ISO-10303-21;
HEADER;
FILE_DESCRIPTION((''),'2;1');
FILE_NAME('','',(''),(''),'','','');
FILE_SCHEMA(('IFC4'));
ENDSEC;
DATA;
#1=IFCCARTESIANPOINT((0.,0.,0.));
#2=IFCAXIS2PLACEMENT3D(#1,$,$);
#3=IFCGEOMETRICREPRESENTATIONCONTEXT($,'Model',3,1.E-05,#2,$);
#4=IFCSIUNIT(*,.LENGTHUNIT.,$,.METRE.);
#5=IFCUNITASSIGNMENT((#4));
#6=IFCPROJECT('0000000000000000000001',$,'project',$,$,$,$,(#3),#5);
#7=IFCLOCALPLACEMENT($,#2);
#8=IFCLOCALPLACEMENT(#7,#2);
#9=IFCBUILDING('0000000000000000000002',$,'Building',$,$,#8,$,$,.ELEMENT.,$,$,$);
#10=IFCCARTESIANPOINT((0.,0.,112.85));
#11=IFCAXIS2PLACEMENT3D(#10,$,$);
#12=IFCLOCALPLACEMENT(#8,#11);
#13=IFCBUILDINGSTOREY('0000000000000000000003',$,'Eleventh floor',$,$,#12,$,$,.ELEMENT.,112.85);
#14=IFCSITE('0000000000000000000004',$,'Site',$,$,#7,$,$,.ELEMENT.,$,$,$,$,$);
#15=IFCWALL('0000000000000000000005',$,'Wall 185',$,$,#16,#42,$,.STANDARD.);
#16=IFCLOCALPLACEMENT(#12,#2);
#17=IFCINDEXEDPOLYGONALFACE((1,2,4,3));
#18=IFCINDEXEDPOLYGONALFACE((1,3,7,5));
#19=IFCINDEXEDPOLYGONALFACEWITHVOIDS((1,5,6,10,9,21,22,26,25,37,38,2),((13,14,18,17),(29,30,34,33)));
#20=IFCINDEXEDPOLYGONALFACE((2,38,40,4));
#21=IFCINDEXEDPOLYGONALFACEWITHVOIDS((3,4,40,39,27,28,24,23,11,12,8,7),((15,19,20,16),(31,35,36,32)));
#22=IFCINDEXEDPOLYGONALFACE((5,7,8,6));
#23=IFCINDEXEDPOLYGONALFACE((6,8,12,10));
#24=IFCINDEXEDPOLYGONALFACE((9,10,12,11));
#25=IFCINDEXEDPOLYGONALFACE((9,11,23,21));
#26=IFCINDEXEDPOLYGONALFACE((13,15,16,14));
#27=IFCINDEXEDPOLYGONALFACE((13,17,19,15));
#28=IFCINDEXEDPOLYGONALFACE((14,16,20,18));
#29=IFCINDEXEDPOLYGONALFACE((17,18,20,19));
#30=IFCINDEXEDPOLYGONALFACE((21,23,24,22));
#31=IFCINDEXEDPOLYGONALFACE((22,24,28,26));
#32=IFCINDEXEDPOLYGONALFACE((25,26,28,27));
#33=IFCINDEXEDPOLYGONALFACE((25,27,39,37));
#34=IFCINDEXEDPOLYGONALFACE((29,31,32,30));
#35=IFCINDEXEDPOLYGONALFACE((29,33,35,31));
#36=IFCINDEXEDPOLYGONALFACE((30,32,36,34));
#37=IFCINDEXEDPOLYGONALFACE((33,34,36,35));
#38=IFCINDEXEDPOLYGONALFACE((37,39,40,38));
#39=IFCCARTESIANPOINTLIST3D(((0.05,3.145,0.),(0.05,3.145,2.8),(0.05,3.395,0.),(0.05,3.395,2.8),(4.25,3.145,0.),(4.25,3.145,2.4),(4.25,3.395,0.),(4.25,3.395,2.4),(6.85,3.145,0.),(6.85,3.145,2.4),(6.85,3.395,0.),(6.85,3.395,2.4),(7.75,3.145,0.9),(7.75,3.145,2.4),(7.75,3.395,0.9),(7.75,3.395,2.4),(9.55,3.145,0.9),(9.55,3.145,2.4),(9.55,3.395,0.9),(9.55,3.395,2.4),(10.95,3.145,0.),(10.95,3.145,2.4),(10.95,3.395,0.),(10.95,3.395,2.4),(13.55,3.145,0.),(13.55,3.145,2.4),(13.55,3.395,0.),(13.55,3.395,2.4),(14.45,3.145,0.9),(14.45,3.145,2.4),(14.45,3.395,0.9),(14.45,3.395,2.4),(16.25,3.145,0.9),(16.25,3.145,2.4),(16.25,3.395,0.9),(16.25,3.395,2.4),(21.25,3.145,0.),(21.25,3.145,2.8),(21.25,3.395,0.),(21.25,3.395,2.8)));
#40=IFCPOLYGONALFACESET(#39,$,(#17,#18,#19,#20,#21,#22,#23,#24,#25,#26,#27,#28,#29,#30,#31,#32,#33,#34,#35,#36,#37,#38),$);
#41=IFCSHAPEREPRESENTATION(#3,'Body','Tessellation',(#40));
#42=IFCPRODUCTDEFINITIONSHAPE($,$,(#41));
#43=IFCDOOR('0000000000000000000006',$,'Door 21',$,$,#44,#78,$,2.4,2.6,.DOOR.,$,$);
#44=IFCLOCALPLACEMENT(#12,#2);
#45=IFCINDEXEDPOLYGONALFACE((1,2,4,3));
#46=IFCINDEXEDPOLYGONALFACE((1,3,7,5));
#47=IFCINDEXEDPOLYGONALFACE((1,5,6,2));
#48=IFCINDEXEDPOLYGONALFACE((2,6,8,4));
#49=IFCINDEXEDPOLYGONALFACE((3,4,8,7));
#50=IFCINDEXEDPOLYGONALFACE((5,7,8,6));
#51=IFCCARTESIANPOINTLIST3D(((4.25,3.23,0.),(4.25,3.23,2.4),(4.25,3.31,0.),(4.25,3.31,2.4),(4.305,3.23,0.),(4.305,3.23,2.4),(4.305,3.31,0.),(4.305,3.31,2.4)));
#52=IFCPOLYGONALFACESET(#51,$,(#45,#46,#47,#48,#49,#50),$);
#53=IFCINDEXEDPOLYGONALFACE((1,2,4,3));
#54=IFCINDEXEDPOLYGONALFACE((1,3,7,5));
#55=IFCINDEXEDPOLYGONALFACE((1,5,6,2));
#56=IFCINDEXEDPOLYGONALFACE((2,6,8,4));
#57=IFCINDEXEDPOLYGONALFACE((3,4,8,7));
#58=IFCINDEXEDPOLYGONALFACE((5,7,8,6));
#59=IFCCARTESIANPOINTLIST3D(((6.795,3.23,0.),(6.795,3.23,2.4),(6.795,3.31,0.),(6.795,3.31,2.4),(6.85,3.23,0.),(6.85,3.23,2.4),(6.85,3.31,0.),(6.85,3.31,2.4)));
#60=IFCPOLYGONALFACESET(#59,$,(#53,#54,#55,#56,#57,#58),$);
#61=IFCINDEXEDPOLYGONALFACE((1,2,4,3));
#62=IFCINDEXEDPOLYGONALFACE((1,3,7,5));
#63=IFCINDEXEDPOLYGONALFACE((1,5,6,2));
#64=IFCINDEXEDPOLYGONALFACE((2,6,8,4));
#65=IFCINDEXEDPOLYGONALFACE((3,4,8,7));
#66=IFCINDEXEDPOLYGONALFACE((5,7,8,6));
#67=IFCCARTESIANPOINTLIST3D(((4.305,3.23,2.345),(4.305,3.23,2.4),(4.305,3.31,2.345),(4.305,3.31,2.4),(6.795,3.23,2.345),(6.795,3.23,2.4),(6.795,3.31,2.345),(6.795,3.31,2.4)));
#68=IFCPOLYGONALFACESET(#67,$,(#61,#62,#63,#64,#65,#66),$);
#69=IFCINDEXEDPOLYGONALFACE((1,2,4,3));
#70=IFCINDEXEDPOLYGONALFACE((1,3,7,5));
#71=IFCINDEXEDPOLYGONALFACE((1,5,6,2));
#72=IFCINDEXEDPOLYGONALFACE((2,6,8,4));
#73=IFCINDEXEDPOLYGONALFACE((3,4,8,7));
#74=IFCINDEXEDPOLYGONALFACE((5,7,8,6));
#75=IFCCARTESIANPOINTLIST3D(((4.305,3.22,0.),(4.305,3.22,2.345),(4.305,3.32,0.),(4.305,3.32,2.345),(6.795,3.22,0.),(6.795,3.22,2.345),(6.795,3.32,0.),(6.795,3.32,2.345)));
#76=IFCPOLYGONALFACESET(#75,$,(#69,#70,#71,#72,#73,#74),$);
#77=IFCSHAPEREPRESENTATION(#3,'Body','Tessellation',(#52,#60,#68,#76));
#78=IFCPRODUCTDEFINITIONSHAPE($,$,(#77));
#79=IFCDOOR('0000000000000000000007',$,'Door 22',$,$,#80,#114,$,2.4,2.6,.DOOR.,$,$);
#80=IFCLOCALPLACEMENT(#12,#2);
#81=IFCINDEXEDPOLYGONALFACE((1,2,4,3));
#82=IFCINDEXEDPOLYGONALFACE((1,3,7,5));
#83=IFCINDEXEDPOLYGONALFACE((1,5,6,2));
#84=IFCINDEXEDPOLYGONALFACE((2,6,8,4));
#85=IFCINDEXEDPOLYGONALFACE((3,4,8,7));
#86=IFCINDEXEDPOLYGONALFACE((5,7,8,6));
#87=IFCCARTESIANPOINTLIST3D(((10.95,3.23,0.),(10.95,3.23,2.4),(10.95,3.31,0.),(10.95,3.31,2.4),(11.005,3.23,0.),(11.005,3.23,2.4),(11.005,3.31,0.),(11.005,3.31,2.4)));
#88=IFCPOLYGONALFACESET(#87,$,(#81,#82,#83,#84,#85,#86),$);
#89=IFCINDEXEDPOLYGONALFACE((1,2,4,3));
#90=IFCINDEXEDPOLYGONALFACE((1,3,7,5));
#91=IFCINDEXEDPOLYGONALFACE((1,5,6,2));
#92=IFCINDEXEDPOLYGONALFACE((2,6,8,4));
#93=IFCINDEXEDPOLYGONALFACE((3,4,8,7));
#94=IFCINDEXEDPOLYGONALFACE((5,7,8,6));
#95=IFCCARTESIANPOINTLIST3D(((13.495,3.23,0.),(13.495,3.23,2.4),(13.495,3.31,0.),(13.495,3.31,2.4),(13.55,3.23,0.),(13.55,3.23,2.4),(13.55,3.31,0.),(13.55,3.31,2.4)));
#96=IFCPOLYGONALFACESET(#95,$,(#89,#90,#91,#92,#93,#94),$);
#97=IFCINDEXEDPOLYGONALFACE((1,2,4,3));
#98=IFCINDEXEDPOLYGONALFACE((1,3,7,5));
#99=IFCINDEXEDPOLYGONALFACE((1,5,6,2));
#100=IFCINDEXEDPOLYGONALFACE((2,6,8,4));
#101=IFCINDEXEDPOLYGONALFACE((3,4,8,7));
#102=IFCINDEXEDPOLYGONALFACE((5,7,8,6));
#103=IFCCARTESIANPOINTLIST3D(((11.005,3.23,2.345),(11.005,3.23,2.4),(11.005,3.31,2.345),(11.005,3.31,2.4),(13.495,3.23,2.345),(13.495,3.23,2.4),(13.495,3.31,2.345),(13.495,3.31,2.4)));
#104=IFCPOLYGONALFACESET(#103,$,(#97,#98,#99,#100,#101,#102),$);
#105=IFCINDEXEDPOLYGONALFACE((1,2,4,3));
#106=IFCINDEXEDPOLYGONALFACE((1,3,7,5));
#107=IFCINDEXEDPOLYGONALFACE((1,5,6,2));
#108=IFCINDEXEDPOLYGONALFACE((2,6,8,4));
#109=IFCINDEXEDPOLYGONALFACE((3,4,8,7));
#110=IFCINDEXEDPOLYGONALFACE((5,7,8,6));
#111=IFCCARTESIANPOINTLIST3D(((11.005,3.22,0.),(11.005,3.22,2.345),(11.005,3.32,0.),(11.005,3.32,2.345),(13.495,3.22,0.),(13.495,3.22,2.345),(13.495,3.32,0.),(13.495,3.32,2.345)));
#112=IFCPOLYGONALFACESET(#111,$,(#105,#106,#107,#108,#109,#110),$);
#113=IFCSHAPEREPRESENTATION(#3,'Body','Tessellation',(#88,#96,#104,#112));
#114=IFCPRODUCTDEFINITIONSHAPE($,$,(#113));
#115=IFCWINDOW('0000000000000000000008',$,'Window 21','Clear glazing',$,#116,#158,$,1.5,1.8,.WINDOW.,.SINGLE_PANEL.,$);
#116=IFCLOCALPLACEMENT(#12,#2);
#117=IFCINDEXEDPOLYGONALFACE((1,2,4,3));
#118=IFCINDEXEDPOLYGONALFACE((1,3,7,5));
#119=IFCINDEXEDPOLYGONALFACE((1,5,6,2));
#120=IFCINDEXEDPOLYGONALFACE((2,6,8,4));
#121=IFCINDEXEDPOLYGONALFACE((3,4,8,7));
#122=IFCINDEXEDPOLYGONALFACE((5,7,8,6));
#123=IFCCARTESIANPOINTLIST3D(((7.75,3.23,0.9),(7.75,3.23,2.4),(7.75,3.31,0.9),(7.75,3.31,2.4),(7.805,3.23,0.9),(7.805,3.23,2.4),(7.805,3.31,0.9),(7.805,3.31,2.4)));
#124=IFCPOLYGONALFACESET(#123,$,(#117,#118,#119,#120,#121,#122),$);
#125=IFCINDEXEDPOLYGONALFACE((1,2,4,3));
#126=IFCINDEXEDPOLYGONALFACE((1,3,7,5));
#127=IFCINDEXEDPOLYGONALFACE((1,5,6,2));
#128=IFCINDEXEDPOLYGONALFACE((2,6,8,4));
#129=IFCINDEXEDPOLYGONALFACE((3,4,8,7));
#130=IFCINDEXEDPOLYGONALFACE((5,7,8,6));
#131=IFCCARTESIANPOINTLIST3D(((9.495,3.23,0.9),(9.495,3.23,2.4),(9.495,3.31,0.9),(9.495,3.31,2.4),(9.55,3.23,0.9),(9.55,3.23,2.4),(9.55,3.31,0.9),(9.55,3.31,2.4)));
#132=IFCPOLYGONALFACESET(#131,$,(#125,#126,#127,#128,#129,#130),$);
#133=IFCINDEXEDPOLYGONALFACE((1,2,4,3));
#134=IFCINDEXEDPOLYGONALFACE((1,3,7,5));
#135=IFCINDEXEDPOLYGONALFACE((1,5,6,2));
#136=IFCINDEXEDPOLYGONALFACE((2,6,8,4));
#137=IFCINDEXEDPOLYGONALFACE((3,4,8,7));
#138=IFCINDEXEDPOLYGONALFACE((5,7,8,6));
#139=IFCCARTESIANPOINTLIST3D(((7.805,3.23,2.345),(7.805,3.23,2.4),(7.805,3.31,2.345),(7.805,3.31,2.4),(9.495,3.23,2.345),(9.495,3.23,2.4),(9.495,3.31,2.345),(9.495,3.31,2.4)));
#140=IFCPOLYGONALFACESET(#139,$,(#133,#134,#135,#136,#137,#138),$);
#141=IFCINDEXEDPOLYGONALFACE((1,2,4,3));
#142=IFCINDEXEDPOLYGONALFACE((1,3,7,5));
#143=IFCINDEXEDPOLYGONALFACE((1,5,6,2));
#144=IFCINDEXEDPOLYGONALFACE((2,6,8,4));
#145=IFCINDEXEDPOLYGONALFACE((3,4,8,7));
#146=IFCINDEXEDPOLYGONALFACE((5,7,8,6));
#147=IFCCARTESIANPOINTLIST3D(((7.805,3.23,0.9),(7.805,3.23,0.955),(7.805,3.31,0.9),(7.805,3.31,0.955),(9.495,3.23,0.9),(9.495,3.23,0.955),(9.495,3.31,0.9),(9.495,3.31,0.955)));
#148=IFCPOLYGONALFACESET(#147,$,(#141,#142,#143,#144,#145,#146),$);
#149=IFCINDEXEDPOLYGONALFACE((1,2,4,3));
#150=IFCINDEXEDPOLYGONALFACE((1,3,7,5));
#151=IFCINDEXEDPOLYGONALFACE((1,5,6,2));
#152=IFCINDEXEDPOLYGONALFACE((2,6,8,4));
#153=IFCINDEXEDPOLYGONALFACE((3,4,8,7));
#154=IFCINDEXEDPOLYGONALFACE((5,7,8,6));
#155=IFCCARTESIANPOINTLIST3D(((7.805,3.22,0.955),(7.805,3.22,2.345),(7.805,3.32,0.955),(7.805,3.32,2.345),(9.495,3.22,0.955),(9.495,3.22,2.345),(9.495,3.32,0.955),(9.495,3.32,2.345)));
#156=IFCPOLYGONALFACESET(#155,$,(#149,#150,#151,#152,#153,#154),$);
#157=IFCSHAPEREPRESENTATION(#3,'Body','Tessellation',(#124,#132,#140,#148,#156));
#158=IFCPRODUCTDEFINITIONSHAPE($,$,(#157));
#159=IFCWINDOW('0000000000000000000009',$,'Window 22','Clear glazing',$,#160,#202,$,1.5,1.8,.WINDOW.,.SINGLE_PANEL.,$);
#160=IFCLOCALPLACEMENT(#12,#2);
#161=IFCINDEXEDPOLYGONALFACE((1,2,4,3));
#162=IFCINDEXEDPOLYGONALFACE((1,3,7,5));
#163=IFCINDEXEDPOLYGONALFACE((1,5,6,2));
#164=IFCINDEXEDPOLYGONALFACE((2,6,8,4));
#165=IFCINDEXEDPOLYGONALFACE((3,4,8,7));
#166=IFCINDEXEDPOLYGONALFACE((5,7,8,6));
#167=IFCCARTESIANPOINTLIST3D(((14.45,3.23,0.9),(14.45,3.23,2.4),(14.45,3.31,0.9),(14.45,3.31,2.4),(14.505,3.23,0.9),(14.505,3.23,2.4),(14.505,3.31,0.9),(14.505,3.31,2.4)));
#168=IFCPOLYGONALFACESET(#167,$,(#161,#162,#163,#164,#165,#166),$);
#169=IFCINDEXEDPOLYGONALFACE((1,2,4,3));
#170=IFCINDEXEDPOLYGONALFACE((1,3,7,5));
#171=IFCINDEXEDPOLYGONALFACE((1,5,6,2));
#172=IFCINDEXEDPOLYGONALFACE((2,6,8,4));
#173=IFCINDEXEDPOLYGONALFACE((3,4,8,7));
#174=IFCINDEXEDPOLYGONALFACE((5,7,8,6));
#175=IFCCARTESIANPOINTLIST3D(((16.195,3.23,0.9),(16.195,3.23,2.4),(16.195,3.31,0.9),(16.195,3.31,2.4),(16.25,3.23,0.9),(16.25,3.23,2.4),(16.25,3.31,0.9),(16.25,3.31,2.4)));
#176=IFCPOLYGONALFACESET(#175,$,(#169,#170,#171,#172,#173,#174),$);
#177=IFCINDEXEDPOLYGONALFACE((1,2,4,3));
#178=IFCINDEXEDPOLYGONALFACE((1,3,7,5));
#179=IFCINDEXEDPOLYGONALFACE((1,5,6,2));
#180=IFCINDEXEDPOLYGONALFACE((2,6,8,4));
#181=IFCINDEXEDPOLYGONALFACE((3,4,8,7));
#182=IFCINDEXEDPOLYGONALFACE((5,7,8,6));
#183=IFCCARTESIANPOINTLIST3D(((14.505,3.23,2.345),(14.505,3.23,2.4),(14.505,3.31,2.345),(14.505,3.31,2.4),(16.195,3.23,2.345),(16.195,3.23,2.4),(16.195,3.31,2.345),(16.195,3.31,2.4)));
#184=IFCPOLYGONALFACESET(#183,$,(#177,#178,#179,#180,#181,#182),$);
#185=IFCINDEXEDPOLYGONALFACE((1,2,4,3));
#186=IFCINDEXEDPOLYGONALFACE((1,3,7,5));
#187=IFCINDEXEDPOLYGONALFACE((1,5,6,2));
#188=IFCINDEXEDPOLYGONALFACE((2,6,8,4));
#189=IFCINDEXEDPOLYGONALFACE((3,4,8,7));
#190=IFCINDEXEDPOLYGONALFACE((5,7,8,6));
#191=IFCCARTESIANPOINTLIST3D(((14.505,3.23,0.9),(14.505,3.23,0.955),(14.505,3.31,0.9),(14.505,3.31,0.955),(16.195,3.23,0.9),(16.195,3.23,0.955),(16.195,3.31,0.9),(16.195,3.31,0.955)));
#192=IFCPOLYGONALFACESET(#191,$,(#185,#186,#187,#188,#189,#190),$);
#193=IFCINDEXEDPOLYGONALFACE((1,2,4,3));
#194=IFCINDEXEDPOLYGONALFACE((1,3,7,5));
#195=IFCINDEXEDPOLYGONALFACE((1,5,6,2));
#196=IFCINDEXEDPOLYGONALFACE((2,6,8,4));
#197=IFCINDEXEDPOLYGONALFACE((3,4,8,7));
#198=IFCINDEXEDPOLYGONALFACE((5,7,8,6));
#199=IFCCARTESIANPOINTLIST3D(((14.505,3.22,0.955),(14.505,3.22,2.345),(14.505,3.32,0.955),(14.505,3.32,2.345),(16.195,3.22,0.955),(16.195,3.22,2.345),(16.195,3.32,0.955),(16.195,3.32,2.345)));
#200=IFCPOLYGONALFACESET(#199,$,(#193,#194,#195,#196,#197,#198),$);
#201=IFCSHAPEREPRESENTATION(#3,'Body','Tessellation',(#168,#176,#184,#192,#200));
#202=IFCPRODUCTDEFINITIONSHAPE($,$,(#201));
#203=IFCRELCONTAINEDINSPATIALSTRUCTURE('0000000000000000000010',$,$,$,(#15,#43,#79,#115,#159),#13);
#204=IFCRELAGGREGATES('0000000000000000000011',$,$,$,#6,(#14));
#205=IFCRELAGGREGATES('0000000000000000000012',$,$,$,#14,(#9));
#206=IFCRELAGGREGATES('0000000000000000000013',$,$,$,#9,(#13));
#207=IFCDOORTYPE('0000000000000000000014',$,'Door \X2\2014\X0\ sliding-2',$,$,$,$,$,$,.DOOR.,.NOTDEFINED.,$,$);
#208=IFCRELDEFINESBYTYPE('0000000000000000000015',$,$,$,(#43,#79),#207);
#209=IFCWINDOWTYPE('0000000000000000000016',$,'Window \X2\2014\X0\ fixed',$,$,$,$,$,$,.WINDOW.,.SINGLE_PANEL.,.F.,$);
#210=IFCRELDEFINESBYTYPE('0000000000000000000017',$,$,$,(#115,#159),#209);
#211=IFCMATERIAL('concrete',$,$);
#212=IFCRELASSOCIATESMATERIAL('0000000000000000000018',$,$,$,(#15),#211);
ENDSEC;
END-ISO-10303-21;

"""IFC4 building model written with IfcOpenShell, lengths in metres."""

from ifc_helpers import new_model, si_unit, frame, frame_2d, origin, place, context, project, spatial, rectangle, extrude, material, type_object, element, fill, save


model = new_model("IFC4")

# Units and contexts
model_context = context("Model", 3, precision=1e-05, world=origin())
ifc_project = project(units=[si_unit("LENGTHUNIT", "METRE")], contexts=[model_context])

# Site, building, storey
site_placement = place(None, origin())
site = spatial("IfcSite", under=ifc_project, at=site_placement, Name="Site", CompositionType="ELEMENT")
building_placement = place(site_placement, origin())
building = spatial("IfcBuilding", under=site, at=building_placement, Name="Building", CompositionType="ELEMENT")
storey_placement = place(building_placement, frame((0.0, 0.0, 112.85)))
storey = spatial("IfcBuildingStorey", under=building, at=storey_placement, Name="Eleventh floor", CompositionType="ELEMENT", Elevation=112.85)

# Shared definitions
ifc_material = material(Name="concrete")

# Wall, openings, doors, windows
wall_1_placement = place(storey_placement, frame((0.05, 3.27, 0.0), z_axis=(0.0, 0.0, 1.0), x_axis=(1.0, 0.0, 0.0)))
wall_1 = element("IfcWall", 1, at=wall_1_placement, inside=storey, material=ifc_material, Name="Wall 185", PredefinedType="STANDARD", context=model_context, shape_type="SweptSolid", body=[
    extrude(rectangle(XDim=21.2, YDim=0.25, at=frame_2d((10.6, 0.0))), origin(), (0.0, 0.0, 1.0), 2.8),
])
opening_1_placement = place(storey_placement, frame((4.25, 3.27, 0.0), z_axis=(0.0, 0.0, 1.0), x_axis=(1.0, 0.0, 0.0)))
opening_1 = element("IfcOpeningElement", 2, at=opening_1_placement, cuts=wall_1, PredefinedType="OPENING", context=model_context, shape_type="SweptSolid", body=[
    extrude(rectangle(XDim=2.6, YDim=0.31, at=frame_2d((1.3, 0.0))), origin(), (0.0, 0.0, 1.0), 2.4),
])
opening_2_placement = place(storey_placement, frame((7.75, 3.27, 0.9), z_axis=(0.0, 0.0, 1.0), x_axis=(1.0, 0.0, 0.0)))
opening_2 = element("IfcOpeningElement", 3, at=opening_2_placement, cuts=wall_1, PredefinedType="OPENING", context=model_context, shape_type="SweptSolid", body=[
    extrude(rectangle(XDim=1.8, YDim=0.31, at=frame_2d((0.9, 0.0))), origin(), (0.0, 0.0, 1.0), 1.5),
])
opening_3_placement = place(storey_placement, frame((10.95, 3.27, 0.0), z_axis=(0.0, 0.0, 1.0), x_axis=(1.0, 0.0, 0.0)))
opening_3 = element("IfcOpeningElement", 4, at=opening_3_placement, cuts=wall_1, PredefinedType="OPENING", context=model_context, shape_type="SweptSolid", body=[
    extrude(rectangle(XDim=2.6, YDim=0.31, at=frame_2d((1.3, 0.0))), origin(), (0.0, 0.0, 1.0), 2.4),
])
opening_4_placement = place(storey_placement, frame((14.45, 3.27, 0.9), z_axis=(0.0, 0.0, 1.0), x_axis=(1.0, 0.0, 0.0)))
opening_4 = element("IfcOpeningElement", 5, at=opening_4_placement, cuts=wall_1, PredefinedType="OPENING", context=model_context, shape_type="SweptSolid", body=[
    extrude(rectangle(XDim=1.8, YDim=0.31, at=frame_2d((0.9, 0.0))), origin(), (0.0, 0.0, 1.0), 1.5),
])
door_type = type_object("IfcDoorType", Name="Door — sliding-2", PredefinedType="DOOR")
door_1_placement = place(storey_placement, frame((4.25, 3.27, 0.0), z_axis=(0.0, 0.0, 1.0), x_axis=(1.0, 0.0, 0.0)))
door_1 = element("IfcDoor", 6, at=door_1_placement, inside=storey, type_object=door_type, Name="Door 21", OverallHeight=2.4, OverallWidth=2.6, PredefinedType="DOOR", context=model_context, shape_type="SweptSolid", body=[
    extrude(rectangle(XDim=0.055, YDim=0.08, at=frame_2d((0.0275, 0.0))), origin(), (0.0, 0.0, 1.0), 2.4),
    extrude(rectangle(XDim=0.055, YDim=0.08, at=frame_2d((2.5725, 0.0))), origin(), (0.0, 0.0, 1.0), 2.4),
    extrude(rectangle(XDim=2.49, YDim=0.08, at=frame_2d((1.3, 0.0))), frame((0.0, 0.0, 2.345)), (0.0, 0.0, 1.0), 0.055),
    extrude(rectangle(XDim=2.49, YDim=0.1, at=frame_2d((1.3, 0.0))), origin(), (0.0, 0.0, 1.0), 2.345),
])
fill(opening_1, door_1)
door_2_placement = place(storey_placement, frame((10.95, 3.27, 0.0), z_axis=(0.0, 0.0, 1.0), x_axis=(1.0, 0.0, 0.0)))
door_2 = element("IfcDoor", 7, at=door_2_placement, inside=storey, type_object=door_type, Name="Door 22", OverallHeight=2.4, OverallWidth=2.6, PredefinedType="DOOR", context=model_context, shape_type="SweptSolid", body=[
    extrude(rectangle(XDim=0.055, YDim=0.08, at=frame_2d((0.0275, 0.0))), origin(), (0.0, 0.0, 1.0), 2.4),
    extrude(rectangle(XDim=0.055, YDim=0.08, at=frame_2d((2.5725, 0.0))), origin(), (0.0, 0.0, 1.0), 2.4),
    extrude(rectangle(XDim=2.49, YDim=0.08, at=frame_2d((1.3, 0.0))), frame((0.0, 0.0, 2.345)), (0.0, 0.0, 1.0), 0.055),
    extrude(rectangle(XDim=2.49, YDim=0.1, at=frame_2d((1.3, 0.0))), origin(), (0.0, 0.0, 1.0), 2.345),
])
fill(opening_3, door_2)
window_type = type_object("IfcWindowType", Name="Window — fixed", ParameterTakesPrecedence=False, PartitioningType="SINGLE_PANEL", PredefinedType="WINDOW")
window_1_placement = place(storey_placement, frame((7.75, 3.27, 0.9), z_axis=(0.0, 0.0, 1.0), x_axis=(1.0, 0.0, 0.0)))
window_1 = element("IfcWindow", 8, at=window_1_placement, inside=storey, type_object=window_type, Name="Window 21", Description="Clear glazing", OverallHeight=1.5, OverallWidth=1.8, PartitioningType="SINGLE_PANEL", PredefinedType="WINDOW", context=model_context, shape_type="SweptSolid", body=[
    extrude(rectangle(XDim=0.055, YDim=0.08, at=frame_2d((0.0275, 0.0))), origin(), (0.0, 0.0, 1.0), 1.5),
    extrude(rectangle(XDim=0.055, YDim=0.08, at=frame_2d((1.7725, 0.0))), origin(), (0.0, 0.0, 1.0), 1.5),
    extrude(rectangle(XDim=1.69, YDim=0.08, at=frame_2d((0.9, 0.0))), frame((0.0, 0.0, 1.445)), (0.0, 0.0, 1.0), 0.055),
    extrude(rectangle(XDim=1.69, YDim=0.08, at=frame_2d((0.9, 0.0))), origin(), (0.0, 0.0, 1.0), 0.055),
    extrude(rectangle(XDim=1.69, YDim=0.1, at=frame_2d((0.9, 0.0))), frame((0.0, 0.0, 0.055)), (0.0, 0.0, 1.0), 1.39),
])
fill(opening_2, window_1)
window_2_placement = place(storey_placement, frame((14.45, 3.27, 0.9), z_axis=(0.0, 0.0, 1.0), x_axis=(1.0, 0.0, 0.0)))
window_2 = element("IfcWindow", 9, at=window_2_placement, inside=storey, type_object=window_type, Name="Window 22", Description="Clear glazing", OverallHeight=1.5, OverallWidth=1.8, PartitioningType="SINGLE_PANEL", PredefinedType="WINDOW", context=model_context, shape_type="SweptSolid", body=[
    extrude(rectangle(XDim=0.055, YDim=0.08, at=frame_2d((0.0275, 0.0))), origin(), (0.0, 0.0, 1.0), 1.5),
    extrude(rectangle(XDim=0.055, YDim=0.08, at=frame_2d((1.7725, 0.0))), origin(), (0.0, 0.0, 1.0), 1.5),
    extrude(rectangle(XDim=1.69, YDim=0.08, at=frame_2d((0.9, 0.0))), frame((0.0, 0.0, 1.445)), (0.0, 0.0, 1.0), 0.055),
    extrude(rectangle(XDim=1.69, YDim=0.08, at=frame_2d((0.9, 0.0))), origin(), (0.0, 0.0, 1.0), 0.055),
    extrude(rectangle(XDim=1.69, YDim=0.1, at=frame_2d((0.9, 0.0))), frame((0.0, 0.0, 0.055)), (0.0, 0.0, 1.0), 1.39),
])
fill(opening_4, window_2)

save(model, "model.ifc")
